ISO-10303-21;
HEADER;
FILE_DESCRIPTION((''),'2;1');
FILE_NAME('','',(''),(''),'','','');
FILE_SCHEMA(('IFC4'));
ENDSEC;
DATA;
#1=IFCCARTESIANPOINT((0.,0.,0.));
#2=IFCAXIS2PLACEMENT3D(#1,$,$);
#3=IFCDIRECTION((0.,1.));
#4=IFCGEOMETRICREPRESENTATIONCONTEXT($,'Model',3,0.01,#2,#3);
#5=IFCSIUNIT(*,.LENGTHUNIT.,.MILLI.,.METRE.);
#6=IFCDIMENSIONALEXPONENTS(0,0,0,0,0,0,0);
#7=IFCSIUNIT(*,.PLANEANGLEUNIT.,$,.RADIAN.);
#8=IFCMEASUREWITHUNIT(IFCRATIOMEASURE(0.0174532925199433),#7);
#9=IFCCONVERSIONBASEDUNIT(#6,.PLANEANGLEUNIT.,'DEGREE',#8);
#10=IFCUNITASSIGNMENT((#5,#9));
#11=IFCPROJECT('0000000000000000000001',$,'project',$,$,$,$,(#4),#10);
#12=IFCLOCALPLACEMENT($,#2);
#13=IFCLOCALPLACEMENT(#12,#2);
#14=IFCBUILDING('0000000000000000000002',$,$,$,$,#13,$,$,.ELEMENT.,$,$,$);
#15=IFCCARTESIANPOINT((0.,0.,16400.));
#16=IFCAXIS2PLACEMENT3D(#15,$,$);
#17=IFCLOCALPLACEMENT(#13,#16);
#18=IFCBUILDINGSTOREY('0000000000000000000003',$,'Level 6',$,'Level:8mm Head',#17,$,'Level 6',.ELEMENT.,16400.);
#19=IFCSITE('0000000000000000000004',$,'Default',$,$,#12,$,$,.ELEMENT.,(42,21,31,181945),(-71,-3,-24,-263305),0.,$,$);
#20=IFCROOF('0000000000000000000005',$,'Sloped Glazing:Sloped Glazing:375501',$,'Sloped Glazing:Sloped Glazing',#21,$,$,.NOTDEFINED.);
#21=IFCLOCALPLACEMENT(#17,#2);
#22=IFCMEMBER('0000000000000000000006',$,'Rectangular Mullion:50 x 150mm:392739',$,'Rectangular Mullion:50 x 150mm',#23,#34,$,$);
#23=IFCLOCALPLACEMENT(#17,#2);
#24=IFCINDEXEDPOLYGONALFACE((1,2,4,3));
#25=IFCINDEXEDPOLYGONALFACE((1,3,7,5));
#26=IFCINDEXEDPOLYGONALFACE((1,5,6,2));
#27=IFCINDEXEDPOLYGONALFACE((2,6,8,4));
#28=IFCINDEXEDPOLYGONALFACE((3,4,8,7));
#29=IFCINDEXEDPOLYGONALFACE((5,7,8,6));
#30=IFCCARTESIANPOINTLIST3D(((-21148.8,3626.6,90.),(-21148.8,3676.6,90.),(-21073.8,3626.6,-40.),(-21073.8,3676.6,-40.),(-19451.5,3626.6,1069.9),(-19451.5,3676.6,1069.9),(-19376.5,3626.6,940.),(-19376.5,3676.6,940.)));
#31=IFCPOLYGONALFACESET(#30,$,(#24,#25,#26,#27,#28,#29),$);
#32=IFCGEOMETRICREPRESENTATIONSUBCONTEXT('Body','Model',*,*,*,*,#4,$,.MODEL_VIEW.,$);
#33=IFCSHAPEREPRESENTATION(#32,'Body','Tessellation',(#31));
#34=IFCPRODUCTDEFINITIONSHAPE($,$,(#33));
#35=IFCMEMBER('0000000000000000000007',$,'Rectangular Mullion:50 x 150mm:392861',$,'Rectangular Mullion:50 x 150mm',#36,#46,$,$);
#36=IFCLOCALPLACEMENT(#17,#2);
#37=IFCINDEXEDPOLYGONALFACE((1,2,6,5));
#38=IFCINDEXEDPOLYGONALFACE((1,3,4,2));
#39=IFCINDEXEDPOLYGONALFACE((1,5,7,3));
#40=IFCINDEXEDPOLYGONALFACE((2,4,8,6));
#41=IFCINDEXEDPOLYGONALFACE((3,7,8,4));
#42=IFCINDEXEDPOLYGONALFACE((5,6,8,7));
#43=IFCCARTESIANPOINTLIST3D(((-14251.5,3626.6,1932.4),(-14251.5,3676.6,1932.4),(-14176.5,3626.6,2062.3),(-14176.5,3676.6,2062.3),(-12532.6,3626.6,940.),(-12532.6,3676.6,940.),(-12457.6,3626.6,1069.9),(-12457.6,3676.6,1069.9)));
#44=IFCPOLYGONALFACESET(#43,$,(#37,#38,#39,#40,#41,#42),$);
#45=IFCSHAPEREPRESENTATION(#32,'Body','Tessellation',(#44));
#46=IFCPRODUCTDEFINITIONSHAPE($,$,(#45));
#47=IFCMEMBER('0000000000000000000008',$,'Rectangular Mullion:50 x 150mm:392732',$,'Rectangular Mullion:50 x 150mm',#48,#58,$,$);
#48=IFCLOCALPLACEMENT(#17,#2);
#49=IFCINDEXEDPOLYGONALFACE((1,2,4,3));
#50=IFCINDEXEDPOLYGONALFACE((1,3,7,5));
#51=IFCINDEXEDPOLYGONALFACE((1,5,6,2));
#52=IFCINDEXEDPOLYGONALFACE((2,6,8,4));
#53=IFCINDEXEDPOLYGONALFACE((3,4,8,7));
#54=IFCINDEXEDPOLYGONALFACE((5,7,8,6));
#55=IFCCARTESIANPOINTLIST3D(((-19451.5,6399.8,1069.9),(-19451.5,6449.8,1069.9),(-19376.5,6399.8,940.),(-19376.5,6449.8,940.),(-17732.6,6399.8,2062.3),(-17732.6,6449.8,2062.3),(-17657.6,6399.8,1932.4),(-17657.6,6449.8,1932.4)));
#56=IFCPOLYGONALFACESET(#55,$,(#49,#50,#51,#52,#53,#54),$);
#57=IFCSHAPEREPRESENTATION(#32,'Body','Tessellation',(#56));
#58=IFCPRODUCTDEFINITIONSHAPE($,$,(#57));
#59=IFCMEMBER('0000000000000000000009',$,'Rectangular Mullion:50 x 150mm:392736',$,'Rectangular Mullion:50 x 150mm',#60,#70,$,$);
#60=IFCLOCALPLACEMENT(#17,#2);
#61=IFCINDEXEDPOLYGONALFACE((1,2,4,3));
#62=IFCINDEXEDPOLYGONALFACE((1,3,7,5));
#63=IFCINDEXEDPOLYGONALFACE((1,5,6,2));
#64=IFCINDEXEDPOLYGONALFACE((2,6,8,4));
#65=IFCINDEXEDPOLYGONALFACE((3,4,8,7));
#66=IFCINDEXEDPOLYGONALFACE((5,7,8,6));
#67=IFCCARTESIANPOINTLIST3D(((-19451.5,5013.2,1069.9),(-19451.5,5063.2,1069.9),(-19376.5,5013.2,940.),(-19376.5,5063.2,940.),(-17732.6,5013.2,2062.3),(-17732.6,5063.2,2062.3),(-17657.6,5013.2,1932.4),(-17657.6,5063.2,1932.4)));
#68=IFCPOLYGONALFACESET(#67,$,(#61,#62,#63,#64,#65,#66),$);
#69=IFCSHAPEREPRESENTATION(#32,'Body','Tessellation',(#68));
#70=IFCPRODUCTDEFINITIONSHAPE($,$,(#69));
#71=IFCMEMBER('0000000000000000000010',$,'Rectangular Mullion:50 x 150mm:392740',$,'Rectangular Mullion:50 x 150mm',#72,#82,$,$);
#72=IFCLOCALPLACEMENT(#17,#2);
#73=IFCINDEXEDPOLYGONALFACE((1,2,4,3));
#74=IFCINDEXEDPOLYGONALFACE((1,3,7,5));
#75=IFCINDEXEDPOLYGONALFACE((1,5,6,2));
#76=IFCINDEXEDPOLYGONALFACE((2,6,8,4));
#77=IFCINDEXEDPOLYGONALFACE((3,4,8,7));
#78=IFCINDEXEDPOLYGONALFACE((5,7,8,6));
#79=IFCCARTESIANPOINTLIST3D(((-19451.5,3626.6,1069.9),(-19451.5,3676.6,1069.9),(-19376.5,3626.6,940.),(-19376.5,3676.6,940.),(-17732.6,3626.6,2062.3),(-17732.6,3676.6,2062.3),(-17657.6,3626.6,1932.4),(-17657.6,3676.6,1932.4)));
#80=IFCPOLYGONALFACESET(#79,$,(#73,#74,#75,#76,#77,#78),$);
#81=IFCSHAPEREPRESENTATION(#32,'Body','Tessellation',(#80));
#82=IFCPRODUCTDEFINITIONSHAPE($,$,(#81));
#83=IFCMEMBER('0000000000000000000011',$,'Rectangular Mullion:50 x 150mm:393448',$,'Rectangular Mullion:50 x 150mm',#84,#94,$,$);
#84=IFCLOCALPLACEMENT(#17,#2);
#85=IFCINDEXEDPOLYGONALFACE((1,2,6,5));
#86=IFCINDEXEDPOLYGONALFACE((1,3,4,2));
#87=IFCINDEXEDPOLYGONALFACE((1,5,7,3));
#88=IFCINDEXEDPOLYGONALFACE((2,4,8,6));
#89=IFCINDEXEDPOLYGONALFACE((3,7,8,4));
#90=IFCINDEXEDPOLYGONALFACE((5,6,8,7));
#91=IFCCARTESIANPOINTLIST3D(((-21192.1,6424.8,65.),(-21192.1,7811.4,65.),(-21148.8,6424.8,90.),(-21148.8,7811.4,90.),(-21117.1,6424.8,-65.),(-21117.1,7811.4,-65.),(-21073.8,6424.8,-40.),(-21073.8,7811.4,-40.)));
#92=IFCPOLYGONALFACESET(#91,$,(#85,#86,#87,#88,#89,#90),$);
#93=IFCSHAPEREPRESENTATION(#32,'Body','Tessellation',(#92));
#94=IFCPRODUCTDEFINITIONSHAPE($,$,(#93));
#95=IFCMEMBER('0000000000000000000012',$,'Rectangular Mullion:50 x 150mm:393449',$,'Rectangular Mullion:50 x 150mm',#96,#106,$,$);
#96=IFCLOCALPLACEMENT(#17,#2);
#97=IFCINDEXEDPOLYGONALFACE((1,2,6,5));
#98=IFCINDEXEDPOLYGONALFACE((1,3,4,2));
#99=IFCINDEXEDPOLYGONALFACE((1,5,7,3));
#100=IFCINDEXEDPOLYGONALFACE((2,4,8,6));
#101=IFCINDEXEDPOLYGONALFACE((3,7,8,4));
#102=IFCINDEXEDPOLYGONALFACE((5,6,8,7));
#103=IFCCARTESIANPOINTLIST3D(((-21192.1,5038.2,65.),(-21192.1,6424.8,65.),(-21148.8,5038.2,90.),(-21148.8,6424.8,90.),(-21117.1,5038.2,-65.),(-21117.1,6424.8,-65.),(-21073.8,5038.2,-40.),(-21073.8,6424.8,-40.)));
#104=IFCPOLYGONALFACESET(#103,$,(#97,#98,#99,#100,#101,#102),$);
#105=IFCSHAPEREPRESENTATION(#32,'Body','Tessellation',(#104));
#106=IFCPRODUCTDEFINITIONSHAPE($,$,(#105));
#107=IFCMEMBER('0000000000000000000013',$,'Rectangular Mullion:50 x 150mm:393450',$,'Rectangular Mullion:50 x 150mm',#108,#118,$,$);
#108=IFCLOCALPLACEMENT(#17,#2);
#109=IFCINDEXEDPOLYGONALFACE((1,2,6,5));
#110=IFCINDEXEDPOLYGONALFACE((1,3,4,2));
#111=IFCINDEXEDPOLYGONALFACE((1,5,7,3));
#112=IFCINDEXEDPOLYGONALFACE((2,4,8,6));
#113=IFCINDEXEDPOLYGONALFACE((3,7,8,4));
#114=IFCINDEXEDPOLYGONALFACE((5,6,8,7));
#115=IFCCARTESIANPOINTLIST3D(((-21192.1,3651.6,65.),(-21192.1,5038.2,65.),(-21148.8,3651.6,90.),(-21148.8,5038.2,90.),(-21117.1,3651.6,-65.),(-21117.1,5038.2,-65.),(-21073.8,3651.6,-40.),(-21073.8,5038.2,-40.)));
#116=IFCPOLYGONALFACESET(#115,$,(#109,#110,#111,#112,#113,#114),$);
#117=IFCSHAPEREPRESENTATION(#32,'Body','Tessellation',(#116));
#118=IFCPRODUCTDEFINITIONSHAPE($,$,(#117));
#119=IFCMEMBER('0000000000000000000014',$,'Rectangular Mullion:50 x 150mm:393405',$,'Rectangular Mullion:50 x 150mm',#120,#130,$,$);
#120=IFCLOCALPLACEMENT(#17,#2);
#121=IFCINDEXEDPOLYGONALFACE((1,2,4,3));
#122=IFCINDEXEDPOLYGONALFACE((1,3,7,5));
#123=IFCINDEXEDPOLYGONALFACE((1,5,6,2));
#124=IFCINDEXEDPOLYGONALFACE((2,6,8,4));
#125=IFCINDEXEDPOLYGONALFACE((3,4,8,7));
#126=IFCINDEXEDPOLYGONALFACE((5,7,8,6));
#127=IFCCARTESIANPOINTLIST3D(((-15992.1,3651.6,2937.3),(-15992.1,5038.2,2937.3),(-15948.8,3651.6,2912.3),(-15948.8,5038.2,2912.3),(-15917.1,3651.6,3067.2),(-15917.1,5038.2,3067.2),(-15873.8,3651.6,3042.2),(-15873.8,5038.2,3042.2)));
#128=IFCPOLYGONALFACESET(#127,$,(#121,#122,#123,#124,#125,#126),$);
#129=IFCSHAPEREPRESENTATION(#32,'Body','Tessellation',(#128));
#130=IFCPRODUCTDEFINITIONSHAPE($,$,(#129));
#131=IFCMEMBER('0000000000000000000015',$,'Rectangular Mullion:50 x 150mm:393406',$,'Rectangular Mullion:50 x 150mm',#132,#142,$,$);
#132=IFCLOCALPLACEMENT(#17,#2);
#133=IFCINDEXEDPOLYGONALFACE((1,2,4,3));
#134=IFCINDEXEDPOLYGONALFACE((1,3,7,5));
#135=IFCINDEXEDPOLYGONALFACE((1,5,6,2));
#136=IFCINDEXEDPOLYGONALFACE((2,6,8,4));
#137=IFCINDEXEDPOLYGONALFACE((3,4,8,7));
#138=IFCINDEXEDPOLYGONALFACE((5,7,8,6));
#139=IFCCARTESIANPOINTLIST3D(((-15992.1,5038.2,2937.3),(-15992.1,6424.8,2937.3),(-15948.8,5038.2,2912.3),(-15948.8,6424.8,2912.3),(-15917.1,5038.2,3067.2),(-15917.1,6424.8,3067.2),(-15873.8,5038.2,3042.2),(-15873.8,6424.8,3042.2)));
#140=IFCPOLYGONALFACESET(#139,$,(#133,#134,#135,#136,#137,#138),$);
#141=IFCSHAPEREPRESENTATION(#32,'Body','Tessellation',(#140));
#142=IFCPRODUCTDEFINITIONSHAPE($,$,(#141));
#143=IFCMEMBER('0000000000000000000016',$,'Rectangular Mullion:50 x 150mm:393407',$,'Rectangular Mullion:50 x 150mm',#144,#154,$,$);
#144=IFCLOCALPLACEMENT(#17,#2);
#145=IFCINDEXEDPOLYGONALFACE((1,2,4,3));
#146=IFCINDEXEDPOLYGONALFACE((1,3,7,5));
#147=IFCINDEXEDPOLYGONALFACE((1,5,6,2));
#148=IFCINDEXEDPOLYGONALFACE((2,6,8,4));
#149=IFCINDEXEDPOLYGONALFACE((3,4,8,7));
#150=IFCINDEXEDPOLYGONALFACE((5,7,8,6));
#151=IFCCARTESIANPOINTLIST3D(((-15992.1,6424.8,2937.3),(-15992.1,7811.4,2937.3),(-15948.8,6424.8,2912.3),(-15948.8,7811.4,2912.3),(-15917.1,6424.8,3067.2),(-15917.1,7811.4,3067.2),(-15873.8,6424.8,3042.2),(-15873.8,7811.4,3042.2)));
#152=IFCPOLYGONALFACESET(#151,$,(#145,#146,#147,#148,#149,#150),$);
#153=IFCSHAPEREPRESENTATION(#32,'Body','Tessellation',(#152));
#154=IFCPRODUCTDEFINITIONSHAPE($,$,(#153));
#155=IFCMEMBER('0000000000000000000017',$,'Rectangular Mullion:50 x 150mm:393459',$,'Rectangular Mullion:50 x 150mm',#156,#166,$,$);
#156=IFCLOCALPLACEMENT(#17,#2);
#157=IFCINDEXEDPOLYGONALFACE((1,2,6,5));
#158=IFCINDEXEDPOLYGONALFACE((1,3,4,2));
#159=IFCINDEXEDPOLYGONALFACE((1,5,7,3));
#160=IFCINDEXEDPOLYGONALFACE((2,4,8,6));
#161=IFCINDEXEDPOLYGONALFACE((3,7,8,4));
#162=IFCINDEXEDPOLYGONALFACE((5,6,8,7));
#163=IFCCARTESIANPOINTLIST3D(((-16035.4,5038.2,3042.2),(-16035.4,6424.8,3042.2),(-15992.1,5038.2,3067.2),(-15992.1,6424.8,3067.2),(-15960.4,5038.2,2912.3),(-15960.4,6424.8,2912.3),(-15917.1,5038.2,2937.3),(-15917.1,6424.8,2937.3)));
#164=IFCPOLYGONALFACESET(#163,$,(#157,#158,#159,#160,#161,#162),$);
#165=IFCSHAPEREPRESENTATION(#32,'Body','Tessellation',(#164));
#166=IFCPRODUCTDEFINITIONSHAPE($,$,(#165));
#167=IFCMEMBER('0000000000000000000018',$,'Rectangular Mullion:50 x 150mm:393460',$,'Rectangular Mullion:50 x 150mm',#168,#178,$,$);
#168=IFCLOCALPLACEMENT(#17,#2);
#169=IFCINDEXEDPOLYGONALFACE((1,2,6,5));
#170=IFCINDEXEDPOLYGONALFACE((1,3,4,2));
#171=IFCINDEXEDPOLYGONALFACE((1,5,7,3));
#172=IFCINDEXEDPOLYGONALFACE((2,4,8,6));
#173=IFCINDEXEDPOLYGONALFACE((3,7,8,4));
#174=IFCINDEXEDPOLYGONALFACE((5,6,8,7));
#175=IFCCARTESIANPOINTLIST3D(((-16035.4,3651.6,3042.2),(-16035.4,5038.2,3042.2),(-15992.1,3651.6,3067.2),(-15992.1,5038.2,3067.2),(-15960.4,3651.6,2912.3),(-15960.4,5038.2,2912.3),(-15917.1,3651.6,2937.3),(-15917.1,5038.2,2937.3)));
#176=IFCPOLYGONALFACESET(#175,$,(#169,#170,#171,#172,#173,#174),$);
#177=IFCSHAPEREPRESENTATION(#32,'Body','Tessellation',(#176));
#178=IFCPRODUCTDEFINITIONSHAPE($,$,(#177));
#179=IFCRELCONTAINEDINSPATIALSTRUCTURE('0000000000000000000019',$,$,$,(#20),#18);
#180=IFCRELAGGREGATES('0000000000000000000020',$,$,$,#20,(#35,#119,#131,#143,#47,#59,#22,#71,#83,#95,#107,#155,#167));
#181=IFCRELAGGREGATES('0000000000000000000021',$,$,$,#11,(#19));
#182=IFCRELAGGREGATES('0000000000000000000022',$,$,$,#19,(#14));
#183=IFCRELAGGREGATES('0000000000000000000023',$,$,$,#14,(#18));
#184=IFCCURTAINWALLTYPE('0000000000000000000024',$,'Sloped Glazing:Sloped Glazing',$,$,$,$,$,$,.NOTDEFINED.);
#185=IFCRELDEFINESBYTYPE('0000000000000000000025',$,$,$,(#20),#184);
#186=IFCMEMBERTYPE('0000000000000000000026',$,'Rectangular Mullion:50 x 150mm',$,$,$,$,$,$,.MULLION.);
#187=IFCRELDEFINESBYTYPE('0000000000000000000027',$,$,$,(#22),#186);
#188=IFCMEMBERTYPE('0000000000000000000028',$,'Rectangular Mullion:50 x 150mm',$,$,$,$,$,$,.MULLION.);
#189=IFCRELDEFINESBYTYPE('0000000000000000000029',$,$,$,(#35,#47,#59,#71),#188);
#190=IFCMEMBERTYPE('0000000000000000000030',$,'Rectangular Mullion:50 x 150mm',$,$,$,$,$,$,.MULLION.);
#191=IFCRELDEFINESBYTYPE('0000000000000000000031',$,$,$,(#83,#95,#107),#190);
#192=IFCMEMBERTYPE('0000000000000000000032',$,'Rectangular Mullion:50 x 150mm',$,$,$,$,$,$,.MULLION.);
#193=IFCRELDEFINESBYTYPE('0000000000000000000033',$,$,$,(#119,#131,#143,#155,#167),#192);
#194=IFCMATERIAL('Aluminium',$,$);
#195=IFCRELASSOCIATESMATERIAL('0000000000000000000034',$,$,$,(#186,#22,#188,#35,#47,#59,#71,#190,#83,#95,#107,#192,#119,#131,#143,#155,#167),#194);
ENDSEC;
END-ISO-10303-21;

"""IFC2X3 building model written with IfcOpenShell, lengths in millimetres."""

from ifc_helpers import new_model, entity, si_unit, converted_unit, direction, frame, origin, origin_2d_with_axis, place, context, subcontext, project, spatial, rectangle, extrude, source, transform, mapped, material, type_object, type_shapes, element, aggregate, save


model = new_model("IFC2X3")

# Units and contexts
model_context = context("Model", 3, precision=0.01, world=origin(), true_north=direction((0.0, 1.0)))
body_context = subcontext(model_context, "Body", "Model", "MODEL_VIEW")
ifc_project = project(units=[si_unit("LENGTHUNIT", "METRE", prefix="MILLI"), converted_unit("PLANEANGLEUNIT", "DEGREE", entity("IfcRatioMeasure", 0.0174532925199433), si_unit("PLANEANGLEUNIT", "RADIAN"), dimensions=[0, 0, 0, 0, 0, 0, 0])], contexts=[model_context])

# Site, building, storey
site_placement = place(None, frame((0.0, 0.0, 0.0)))
site = spatial("IfcSite", under=ifc_project, at=site_placement, Name="Default", CompositionType="ELEMENT", RefLatitude=(42, 21, 31, 181945), RefLongitude=(-71, -3, -24, -263305), RefElevation=0.0)
building_placement = place(site_placement, origin())
building = spatial("IfcBuilding", under=site, at=building_placement, CompositionType="ELEMENT")
storey_placement = place(building_placement, frame((0.0, 0.0, 16400.0)))
storey = spatial("IfcBuildingStorey", under=building, at=storey_placement, Name="Level 6", ObjectType="Level:8mm Head", LongName="Level 6", CompositionType="ELEMENT", Elevation=16400.0)

# Roof, members
curtain_wall_type = type_object("IfcCurtainWallType", Name="Sloped Glazing:Sloped Glazing", PredefinedType="NOTDEFINED")
roof_placement = place(storey_placement, frame((0.0, 0.0, -16400.0)))
roof = element("IfcRoof", 1, at=roof_placement, inside=storey, type_object=curtain_wall_type, Name="Sloped Glazing:Sloped Glazing:375501", ObjectType="Sloped Glazing:Sloped Glazing", ShapeType="NOTDEFINED")
ifc_material_1 = material(Name="Aluminium")
member_type_1 = type_object("IfcMemberType", Name="Rectangular Mullion:50 x 150mm", PredefinedType="MULLION", material=ifc_material_1)
shared_shape_1 = source(origin(), body_context, "Body", "SweptSolid", [
    extrude(rectangle(XDim=150.0, YDim=50.0, at=origin_2d_with_axis()), frame((0.0, 0.0, -1959.8), z_axis=(0.0, 0.0, 1.0), x_axis=(0.0, -1.0, 0.0)), (0.0, 0.0, 1.0), 1959.8),
])
type_shapes(member_type_1, [shared_shape_1])
member_1_placement = place(storey_placement, frame((-19414.0, 3651.6, 1004.9), z_axis=(0.866025, 0.0, 0.5), x_axis=(0.0, -1.0, 0.0)))
member_1 = element("IfcMember", 2, at=member_1_placement, type_object=member_type_1, material=ifc_material_1, Name="Rectangular Mullion:50 x 150mm:392739", ObjectType="Rectangular Mullion:50 x 150mm", context=body_context, shape_type="MappedRepresentation", body=[
    mapped(shared_shape_1, transform((0.0, 0.0, 0.0), scale=1.0)),
])
member_type_2 = type_object("IfcMemberType", Name="Rectangular Mullion:50 x 150mm", PredefinedType="MULLION", material=ifc_material_1)
shared_shape_2 = source(origin(), body_context, "Body", "SweptSolid", [
    extrude(rectangle(XDim=150.0, YDim=50.0, at=origin_2d_with_axis()), frame((0.0, 0.0, -1984.8), z_axis=(0.0, 0.0, 1.0), x_axis=(0.0, -1.0, 0.0)), (0.0, 0.0, 1.0), 1984.8),
])
type_shapes(member_type_2, [shared_shape_2])
member_2_placement = place(storey_placement, frame((-14214.0, 3651.6, 1997.3), z_axis=(-0.866025, 0.0, 0.5), x_axis=(0.0, 1.0, 0.0)))
member_2 = element("IfcMember", 3, at=member_2_placement, type_object=member_type_2, material=ifc_material_1, Name="Rectangular Mullion:50 x 150mm:392861", ObjectType="Rectangular Mullion:50 x 150mm", context=body_context, shape_type="MappedRepresentation", body=[
    mapped(shared_shape_2, transform((0.0, 0.0, 0.0), scale=1.0)),
])
member_3_placement = place(storey_placement, frame((-17695.1, 6424.8, 1997.3), z_axis=(0.866025, 0.0, 0.5), x_axis=(0.0, -1.0, 0.0)))
member_3 = element("IfcMember", 4, at=member_3_placement, type_object=member_type_2, material=ifc_material_1, Name="Rectangular Mullion:50 x 150mm:392732", ObjectType="Rectangular Mullion:50 x 150mm", context=body_context, shape_type="MappedRepresentation", body=[
    mapped(shared_shape_2, transform((0.0, 0.0, 0.0), scale=1.0)),
])
member_4_placement = place(storey_placement, frame((-17695.1, 5038.2, 1997.3), z_axis=(0.866025, 0.0, 0.5), x_axis=(0.0, -1.0, 0.0)))
member_4 = element("IfcMember", 5, at=member_4_placement, type_object=member_type_2, material=ifc_material_1, Name="Rectangular Mullion:50 x 150mm:392736", ObjectType="Rectangular Mullion:50 x 150mm", context=body_context, shape_type="MappedRepresentation", body=[
    mapped(shared_shape_2, transform((0.0, 0.0, 0.0), scale=1.0)),
])
member_5_placement = place(storey_placement, frame((-17695.1, 3651.6, 1997.3), z_axis=(0.866025, 0.0, 0.5), x_axis=(0.0, -1.0, 0.0)))
member_5 = element("IfcMember", 6, at=member_5_placement, type_object=member_type_2, material=ifc_material_1, Name="Rectangular Mullion:50 x 150mm:392740", ObjectType="Rectangular Mullion:50 x 150mm", context=body_context, shape_type="MappedRepresentation", body=[
    mapped(shared_shape_2, transform((0.0, 0.0, 0.0), scale=1.0)),
])
member_type_3 = type_object("IfcMemberType", Name="Rectangular Mullion:50 x 150mm", PredefinedType="MULLION", material=ifc_material_1)
shared_shape_3 = source(origin(), body_context, "Body", "SweptSolid", [
    extrude(rectangle(XDim=150.0, YDim=50.0, at=origin_2d_with_axis()), frame((-25.0, 0.0, -1386.6), z_axis=(0.0, 0.0, 1.0), x_axis=(0.0, -1.0, 0.0)), (0.0, 0.0, 1.0), 1386.6),
])
type_shapes(member_type_3, [shared_shape_3])
member_6_placement = place(storey_placement, frame((-21154.6, 6424.8, 0.0), z_axis=(0.0, -1.0, 0.0), x_axis=(-0.866025, 0.0, -0.5)))
member_6 = element("IfcMember", 7, at=member_6_placement, type_object=member_type_3, material=ifc_material_1, Name="Rectangular Mullion:50 x 150mm:393448", ObjectType="Rectangular Mullion:50 x 150mm", context=body_context, shape_type="MappedRepresentation", body=[
    mapped(shared_shape_3, transform((0.0, 0.0, 0.0), scale=1.0)),
])
member_7_placement = place(storey_placement, frame((-21154.6, 5038.2, 0.0), z_axis=(0.0, -1.0, 0.0), x_axis=(-0.866025, 0.0, -0.5)))
member_7 = element("IfcMember", 8, at=member_7_placement, type_object=member_type_3, material=ifc_material_1, Name="Rectangular Mullion:50 x 150mm:393449", ObjectType="Rectangular Mullion:50 x 150mm", context=body_context, shape_type="MappedRepresentation", body=[
    mapped(shared_shape_3, transform((0.0, 0.0, 0.0), scale=1.0)),
])
member_8_placement = place(storey_placement, frame((-21154.6, 3651.6, 0.0), z_axis=(0.0, -1.0, 0.0), x_axis=(-0.866025, 0.0, -0.5)))
member_8 = element("IfcMember", 9, at=member_8_placement, type_object=member_type_3, material=ifc_material_1, Name="Rectangular Mullion:50 x 150mm:393450", ObjectType="Rectangular Mullion:50 x 150mm", context=body_context, shape_type="MappedRepresentation", body=[
    mapped(shared_shape_3, transform((0.0, 0.0, 0.0), scale=1.0)),
])
member_type_4 = type_object("IfcMemberType", Name="Rectangular Mullion:50 x 150mm", PredefinedType="MULLION", material=ifc_material_1)
shared_shape_4 = source(origin(), body_context, "Body", "SweptSolid", [
    extrude(rectangle(XDim=150.0, YDim=50.0, at=origin_2d_with_axis()), frame((-25.0, 0.0, -1386.6), z_axis=(0.0, 0.0, 1.0), x_axis=(0.0, -1.0, 0.0)), (0.0, 0.0, 1.0), 1386.6),
])
type_shapes(member_type_4, [shared_shape_4])
member_9_placement = place(storey_placement, frame((-15954.6, 3651.6, 3002.2), z_axis=(0.0, -1.0, 0.0), x_axis=(-0.866025, 0.0, 0.5)))
member_9 = element("IfcMember", 10, at=member_9_placement, type_object=member_type_4, material=ifc_material_1, Name="Rectangular Mullion:50 x 150mm:393405", ObjectType="Rectangular Mullion:50 x 150mm", context=body_context, shape_type="MappedRepresentation", body=[
    mapped(shared_shape_4, transform((0.0, 0.0, 0.0), scale=1.0)),
])
member_10_placement = place(storey_placement, frame((-15954.6, 5038.2, 3002.2), z_axis=(0.0, -1.0, 0.0), x_axis=(-0.866025, 0.0, 0.5)))
member_10 = element("IfcMember", 11, at=member_10_placement, type_object=member_type_4, material=ifc_material_1, Name="Rectangular Mullion:50 x 150mm:393406", ObjectType="Rectangular Mullion:50 x 150mm", context=body_context, shape_type="MappedRepresentation", body=[
    mapped(shared_shape_4, transform((0.0, 0.0, 0.0), scale=1.0)),
])
member_11_placement = place(storey_placement, frame((-15954.6, 6424.8, 3002.2), z_axis=(0.0, -1.0, 0.0), x_axis=(-0.866025, 0.0, 0.5)))
member_11 = element("IfcMember", 12, at=member_11_placement, type_object=member_type_4, material=ifc_material_1, Name="Rectangular Mullion:50 x 150mm:393407", ObjectType="Rectangular Mullion:50 x 150mm", context=body_context, shape_type="MappedRepresentation", body=[
    mapped(shared_shape_4, transform((0.0, 0.0, 0.0), scale=1.0)),
])
member_12_placement = place(storey_placement, frame((-15954.6, 6424.8, 3002.2), z_axis=(0.0, 1.0, 0.0), x_axis=(0.866025, 0.0, 0.5)))
member_12 = element("IfcMember", 13, at=member_12_placement, type_object=member_type_4, material=ifc_material_1, Name="Rectangular Mullion:50 x 150mm:393459", ObjectType="Rectangular Mullion:50 x 150mm", context=body_context, shape_type="MappedRepresentation", body=[
    mapped(shared_shape_4, transform((0.0, 0.0, 0.0), scale=1.0)),
])
member_13_placement = place(storey_placement, frame((-15954.6, 5038.2, 3002.2), z_axis=(0.0, 1.0, 0.0), x_axis=(0.866025, 0.0, 0.5)))
member_13 = element("IfcMember", 14, at=member_13_placement, type_object=member_type_4, material=ifc_material_1, Name="Rectangular Mullion:50 x 150mm:393460", ObjectType="Rectangular Mullion:50 x 150mm", context=body_context, shape_type="MappedRepresentation", body=[
    mapped(shared_shape_4, transform((0.0, 0.0, 0.0), scale=1.0)),
])
aggregate(roof, [member_2, member_9, member_10, member_11, member_3, member_4, member_1, member_5, member_6, member_7, member_8, member_12, member_13])

save(model, "model.ifc")
